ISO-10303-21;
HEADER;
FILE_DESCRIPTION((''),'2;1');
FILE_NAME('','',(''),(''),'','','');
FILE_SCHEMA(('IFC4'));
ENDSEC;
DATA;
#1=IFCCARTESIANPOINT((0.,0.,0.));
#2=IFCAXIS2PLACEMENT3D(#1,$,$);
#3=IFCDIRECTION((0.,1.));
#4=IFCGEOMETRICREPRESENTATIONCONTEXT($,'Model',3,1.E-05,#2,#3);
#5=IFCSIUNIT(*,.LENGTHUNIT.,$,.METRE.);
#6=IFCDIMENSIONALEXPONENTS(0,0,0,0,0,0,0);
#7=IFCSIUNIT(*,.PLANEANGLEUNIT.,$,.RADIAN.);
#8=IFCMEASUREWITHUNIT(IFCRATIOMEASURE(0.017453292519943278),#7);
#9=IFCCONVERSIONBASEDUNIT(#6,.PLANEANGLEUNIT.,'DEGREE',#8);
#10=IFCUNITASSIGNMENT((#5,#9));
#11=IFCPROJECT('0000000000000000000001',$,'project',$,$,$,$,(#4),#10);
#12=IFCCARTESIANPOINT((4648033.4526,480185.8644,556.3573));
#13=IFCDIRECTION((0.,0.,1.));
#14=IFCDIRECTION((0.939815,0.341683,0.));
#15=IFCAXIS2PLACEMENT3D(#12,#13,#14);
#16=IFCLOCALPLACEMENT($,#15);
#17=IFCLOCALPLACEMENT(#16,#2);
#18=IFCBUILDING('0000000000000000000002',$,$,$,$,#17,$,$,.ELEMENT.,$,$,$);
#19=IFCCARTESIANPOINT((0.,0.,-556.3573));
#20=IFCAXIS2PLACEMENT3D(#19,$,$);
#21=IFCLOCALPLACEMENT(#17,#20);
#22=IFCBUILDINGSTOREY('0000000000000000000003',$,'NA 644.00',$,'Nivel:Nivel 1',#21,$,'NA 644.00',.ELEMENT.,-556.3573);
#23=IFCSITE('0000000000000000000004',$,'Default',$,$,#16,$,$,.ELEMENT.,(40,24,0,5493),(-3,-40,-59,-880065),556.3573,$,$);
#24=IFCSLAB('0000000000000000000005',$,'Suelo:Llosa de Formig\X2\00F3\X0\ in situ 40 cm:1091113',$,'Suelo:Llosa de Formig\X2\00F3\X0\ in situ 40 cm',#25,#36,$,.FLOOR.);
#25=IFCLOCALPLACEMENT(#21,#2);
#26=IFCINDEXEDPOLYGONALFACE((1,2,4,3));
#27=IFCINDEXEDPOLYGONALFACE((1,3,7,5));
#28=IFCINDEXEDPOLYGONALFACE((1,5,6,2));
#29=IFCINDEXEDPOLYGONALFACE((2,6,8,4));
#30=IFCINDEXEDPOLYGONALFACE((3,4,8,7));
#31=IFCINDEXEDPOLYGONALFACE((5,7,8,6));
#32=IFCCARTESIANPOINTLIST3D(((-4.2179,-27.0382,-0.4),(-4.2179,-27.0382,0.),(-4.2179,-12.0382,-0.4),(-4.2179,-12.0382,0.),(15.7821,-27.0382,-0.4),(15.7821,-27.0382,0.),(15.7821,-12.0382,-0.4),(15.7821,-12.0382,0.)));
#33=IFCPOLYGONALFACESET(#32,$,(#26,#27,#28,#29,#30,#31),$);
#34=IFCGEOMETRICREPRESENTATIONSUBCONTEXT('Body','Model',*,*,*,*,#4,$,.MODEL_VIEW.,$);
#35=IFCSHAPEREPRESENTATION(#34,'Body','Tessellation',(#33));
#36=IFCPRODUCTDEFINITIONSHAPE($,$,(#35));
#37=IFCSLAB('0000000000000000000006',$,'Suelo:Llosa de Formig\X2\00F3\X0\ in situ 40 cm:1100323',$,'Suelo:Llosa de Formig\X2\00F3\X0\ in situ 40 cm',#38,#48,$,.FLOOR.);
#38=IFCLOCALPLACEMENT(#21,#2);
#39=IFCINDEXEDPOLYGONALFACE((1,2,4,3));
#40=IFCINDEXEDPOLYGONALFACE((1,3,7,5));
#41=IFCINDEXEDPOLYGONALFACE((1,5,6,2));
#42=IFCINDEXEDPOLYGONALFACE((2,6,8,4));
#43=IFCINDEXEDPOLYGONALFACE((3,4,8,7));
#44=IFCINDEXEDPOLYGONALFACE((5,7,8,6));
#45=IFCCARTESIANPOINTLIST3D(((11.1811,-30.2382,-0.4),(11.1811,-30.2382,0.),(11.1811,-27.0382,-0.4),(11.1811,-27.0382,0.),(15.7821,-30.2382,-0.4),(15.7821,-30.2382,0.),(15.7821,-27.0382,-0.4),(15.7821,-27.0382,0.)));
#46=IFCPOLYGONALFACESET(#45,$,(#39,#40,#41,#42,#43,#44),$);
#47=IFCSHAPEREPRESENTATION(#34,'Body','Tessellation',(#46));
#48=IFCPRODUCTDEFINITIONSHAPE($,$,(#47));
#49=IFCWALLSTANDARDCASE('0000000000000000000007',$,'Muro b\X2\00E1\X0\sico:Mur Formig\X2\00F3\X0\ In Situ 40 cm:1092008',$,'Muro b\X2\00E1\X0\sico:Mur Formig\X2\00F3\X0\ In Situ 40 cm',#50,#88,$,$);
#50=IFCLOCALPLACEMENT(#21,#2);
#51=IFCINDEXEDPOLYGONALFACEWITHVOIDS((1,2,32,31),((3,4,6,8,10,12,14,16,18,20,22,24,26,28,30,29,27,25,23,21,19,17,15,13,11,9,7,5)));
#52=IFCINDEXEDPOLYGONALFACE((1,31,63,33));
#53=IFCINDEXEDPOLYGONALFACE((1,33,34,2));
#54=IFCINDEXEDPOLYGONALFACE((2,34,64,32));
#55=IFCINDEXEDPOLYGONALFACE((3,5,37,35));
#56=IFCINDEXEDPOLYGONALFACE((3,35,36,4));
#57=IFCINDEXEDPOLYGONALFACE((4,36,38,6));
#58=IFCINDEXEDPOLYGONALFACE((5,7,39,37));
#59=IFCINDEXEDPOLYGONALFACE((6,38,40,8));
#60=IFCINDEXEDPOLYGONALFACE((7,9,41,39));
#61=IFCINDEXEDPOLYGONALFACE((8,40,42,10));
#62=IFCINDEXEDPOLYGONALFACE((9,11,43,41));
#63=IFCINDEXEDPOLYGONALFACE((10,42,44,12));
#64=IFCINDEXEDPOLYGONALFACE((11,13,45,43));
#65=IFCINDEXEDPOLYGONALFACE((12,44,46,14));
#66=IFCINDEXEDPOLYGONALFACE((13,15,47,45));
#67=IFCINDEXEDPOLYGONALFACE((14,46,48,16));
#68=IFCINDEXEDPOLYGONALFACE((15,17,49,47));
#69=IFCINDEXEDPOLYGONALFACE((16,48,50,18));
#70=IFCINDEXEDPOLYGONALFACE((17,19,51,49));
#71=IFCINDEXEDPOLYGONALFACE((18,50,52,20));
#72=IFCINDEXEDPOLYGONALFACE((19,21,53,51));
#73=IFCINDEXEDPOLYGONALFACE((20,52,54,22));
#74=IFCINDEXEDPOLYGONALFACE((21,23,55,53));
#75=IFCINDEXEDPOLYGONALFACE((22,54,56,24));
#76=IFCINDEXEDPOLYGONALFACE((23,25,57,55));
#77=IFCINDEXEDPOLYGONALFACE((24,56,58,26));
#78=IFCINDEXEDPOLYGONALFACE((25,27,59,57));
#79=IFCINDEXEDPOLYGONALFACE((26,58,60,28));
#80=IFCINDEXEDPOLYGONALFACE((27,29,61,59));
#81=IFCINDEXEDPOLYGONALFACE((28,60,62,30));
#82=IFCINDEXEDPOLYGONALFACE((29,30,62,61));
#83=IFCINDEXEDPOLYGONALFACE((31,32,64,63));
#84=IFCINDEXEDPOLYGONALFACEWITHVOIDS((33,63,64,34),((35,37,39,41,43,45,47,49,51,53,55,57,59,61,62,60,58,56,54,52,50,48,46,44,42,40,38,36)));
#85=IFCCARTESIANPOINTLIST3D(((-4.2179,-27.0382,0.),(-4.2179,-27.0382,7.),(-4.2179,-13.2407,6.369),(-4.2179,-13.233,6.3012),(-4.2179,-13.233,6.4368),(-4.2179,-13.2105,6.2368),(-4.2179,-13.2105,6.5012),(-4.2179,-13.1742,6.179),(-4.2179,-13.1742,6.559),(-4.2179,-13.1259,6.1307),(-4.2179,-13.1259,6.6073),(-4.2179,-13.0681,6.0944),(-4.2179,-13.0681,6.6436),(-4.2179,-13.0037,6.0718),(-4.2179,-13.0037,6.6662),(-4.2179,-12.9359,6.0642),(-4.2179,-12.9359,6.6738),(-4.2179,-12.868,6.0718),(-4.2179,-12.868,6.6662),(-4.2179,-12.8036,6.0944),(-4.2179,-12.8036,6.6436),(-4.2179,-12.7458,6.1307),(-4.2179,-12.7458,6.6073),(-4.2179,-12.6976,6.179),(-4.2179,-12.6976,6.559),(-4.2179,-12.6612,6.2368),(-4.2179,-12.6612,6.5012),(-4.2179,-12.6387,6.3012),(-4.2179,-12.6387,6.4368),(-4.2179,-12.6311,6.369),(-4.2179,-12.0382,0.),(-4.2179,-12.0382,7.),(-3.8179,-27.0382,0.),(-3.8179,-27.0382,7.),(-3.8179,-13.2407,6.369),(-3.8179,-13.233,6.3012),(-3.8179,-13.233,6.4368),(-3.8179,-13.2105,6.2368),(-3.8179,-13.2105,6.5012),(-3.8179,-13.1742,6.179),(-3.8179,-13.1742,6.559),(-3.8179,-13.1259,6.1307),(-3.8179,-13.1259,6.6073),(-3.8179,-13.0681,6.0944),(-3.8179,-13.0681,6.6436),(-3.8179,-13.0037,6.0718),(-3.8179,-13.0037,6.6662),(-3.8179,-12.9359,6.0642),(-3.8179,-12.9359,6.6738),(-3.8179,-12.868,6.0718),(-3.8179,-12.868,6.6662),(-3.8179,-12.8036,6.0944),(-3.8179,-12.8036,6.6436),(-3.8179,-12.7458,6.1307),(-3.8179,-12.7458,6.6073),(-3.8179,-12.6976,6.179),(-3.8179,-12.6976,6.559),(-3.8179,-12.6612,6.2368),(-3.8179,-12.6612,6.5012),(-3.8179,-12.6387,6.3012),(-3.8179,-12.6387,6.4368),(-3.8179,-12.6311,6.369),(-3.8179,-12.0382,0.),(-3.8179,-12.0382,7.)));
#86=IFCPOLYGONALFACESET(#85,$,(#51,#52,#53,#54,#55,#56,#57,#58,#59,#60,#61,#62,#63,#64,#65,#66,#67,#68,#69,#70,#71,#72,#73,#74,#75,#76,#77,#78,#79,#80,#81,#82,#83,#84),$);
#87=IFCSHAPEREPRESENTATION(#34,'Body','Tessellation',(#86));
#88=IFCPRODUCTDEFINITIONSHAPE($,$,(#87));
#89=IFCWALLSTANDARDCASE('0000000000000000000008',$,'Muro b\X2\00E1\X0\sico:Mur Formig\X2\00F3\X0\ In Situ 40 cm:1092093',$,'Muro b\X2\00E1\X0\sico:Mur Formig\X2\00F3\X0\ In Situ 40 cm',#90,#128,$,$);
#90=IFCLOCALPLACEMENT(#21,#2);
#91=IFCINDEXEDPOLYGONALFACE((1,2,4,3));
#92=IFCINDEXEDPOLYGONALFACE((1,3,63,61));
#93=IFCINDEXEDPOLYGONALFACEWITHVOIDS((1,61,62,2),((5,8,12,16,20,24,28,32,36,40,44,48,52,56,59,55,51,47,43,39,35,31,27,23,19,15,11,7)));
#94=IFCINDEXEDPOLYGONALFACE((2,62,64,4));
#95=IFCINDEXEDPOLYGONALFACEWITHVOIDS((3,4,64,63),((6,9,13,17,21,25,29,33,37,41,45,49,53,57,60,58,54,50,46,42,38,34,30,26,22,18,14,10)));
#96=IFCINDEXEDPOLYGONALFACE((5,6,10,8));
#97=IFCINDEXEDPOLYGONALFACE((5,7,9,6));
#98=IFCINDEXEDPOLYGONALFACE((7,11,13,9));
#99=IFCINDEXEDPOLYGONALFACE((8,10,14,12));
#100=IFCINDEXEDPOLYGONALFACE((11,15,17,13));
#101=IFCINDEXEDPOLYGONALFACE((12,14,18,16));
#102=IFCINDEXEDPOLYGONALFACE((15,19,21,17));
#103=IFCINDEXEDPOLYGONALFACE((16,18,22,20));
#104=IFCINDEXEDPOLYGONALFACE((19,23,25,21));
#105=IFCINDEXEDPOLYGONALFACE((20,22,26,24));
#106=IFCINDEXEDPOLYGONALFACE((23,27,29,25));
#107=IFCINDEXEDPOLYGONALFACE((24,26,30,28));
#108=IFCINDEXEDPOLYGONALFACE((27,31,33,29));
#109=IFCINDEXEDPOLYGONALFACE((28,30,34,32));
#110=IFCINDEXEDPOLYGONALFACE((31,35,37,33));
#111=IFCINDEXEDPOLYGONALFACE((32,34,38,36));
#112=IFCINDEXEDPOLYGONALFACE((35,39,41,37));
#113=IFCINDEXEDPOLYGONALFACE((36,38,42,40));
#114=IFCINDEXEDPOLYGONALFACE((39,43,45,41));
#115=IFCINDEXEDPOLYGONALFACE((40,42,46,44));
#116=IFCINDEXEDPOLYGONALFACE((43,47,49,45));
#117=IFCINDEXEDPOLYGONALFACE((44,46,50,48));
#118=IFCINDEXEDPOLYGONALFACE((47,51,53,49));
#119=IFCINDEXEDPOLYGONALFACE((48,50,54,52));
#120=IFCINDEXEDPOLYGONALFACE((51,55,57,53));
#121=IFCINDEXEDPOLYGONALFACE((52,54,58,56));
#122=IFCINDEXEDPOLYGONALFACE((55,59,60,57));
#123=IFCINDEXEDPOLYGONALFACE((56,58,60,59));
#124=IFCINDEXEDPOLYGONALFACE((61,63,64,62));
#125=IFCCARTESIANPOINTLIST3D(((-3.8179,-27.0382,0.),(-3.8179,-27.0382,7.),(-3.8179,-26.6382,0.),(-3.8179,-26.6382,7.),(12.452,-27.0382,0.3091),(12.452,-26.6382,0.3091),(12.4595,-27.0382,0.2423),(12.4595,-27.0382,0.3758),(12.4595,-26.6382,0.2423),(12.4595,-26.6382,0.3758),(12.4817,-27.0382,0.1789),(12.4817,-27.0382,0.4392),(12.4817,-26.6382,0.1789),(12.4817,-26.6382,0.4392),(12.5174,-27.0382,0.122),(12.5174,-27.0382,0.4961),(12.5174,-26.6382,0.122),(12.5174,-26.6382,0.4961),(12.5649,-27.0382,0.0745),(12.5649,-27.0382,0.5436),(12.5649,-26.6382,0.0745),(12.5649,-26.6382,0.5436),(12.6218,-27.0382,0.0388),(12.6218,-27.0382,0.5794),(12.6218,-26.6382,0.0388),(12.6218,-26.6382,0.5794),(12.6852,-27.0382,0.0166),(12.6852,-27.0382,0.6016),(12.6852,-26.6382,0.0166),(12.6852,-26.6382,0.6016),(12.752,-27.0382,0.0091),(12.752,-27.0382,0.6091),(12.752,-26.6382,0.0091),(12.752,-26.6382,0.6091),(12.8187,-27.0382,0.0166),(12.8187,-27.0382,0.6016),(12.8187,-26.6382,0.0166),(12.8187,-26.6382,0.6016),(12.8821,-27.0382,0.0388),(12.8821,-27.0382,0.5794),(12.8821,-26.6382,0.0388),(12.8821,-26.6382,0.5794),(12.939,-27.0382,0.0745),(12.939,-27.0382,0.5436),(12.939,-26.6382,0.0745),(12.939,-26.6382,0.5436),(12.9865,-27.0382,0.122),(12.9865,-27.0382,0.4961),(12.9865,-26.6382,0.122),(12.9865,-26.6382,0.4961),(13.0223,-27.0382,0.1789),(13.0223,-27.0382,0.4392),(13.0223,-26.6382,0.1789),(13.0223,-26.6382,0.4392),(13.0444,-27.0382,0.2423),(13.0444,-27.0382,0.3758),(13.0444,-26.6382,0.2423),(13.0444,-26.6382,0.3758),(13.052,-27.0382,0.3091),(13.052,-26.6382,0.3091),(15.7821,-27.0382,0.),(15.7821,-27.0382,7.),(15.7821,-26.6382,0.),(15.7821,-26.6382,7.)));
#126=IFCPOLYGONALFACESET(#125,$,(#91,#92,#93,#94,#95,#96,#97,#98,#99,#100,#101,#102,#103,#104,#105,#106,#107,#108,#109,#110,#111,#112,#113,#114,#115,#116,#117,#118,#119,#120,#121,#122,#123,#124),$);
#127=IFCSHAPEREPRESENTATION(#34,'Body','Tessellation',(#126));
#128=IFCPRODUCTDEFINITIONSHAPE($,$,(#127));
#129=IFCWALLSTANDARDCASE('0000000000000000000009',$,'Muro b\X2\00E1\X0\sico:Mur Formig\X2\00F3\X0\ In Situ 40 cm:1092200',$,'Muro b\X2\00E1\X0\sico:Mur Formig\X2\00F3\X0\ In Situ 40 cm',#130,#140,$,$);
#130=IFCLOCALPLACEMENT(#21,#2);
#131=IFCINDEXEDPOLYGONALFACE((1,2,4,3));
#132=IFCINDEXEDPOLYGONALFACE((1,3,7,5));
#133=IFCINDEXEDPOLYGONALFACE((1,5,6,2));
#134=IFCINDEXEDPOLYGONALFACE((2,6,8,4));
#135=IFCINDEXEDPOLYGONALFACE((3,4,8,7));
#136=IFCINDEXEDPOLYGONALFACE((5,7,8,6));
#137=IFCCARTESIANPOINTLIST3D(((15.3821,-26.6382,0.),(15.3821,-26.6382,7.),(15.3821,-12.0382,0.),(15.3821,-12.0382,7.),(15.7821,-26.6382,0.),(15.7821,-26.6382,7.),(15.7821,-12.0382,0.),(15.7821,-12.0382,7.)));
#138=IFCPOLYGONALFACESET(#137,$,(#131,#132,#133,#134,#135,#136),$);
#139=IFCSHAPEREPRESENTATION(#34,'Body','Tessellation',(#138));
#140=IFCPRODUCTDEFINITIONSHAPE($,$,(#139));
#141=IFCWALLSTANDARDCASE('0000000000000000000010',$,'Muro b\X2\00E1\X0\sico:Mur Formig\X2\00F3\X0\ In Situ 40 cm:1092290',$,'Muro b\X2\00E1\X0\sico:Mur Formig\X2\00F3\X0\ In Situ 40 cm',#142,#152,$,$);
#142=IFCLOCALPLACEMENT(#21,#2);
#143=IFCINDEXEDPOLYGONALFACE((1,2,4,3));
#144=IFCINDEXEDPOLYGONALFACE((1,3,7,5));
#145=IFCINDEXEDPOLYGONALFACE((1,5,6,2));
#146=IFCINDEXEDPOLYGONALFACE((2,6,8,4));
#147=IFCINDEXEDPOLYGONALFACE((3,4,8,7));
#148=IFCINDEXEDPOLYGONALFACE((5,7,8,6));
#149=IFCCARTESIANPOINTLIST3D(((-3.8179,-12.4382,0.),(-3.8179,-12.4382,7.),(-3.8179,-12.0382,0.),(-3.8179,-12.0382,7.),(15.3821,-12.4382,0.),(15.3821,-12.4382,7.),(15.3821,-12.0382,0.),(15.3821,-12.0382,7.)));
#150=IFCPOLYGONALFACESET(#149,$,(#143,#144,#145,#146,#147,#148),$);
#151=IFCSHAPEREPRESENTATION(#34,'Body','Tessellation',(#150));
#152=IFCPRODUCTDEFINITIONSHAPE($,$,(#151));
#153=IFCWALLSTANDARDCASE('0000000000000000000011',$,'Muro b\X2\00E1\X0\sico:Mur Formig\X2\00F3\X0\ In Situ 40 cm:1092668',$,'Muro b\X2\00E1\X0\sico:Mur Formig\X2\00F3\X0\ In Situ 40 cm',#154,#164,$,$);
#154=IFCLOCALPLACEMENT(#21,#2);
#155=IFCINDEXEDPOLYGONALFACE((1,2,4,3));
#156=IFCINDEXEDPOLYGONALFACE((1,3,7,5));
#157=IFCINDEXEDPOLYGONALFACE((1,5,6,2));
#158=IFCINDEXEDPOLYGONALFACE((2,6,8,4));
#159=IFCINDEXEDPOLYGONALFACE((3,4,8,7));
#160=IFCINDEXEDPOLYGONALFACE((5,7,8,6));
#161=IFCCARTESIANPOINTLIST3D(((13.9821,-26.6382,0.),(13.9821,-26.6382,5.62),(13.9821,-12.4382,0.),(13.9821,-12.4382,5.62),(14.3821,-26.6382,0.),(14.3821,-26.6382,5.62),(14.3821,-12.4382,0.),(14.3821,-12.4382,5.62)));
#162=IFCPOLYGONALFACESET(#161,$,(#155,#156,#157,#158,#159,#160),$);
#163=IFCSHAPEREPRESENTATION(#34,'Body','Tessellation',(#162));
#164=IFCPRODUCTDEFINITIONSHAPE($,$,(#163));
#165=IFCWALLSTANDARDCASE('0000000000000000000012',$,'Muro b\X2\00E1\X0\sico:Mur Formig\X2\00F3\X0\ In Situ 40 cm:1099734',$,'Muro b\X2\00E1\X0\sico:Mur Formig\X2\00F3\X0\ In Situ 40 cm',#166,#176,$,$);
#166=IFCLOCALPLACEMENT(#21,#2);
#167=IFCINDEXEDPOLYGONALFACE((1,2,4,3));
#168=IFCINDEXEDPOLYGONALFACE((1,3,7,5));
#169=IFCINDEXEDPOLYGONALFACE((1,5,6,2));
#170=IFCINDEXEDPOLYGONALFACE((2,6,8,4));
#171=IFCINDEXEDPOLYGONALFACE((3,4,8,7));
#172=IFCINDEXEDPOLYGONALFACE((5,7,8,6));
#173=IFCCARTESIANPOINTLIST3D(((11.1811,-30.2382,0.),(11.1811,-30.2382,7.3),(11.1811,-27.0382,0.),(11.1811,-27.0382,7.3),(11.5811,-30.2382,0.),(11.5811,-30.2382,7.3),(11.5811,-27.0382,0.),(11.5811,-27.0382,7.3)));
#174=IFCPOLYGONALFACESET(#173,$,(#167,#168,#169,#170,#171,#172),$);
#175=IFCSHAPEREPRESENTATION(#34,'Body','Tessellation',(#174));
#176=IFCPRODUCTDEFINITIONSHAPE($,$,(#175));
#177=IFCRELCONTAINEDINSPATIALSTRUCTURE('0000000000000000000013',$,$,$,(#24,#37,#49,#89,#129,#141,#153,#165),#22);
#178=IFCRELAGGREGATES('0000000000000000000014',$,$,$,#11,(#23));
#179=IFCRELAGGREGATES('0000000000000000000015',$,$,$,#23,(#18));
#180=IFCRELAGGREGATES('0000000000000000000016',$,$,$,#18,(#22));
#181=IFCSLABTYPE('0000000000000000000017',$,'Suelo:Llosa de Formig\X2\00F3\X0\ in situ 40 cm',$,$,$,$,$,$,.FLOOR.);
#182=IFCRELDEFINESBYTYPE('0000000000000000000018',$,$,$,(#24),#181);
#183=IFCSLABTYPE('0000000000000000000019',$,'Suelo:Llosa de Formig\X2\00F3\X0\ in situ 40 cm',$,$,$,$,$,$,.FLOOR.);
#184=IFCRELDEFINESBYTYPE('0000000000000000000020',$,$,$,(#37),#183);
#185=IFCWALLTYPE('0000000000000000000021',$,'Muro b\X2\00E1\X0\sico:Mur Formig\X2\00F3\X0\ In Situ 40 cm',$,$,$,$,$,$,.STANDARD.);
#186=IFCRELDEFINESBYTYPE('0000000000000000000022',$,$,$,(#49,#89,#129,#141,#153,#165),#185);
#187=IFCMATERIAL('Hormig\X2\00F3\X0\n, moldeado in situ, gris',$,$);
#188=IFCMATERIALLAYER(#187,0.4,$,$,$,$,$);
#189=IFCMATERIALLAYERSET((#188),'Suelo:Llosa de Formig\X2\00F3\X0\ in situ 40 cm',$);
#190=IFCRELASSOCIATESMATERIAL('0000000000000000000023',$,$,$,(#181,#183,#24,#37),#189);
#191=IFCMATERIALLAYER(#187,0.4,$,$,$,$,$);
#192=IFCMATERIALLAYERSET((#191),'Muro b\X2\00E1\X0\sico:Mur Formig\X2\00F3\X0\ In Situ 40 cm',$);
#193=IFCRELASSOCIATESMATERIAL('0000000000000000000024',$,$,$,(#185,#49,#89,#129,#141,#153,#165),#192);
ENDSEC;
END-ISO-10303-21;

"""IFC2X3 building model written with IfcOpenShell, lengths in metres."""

from ifc_helpers import new_model, entity, si_unit, converted_unit, direction, frame, frame_2d, origin, origin_2d_with_axis, place, context, subcontext, project, spatial, rectangle, circle, extrude, material, layer, layer_set, layer_usage, type_object, element, save


model = new_model("IFC2X3")

# Units and contexts
model_context = context("Model", 3, precision=1e-05, world=origin(), true_north=direction((0.0, 1.0)))
body_context = subcontext(model_context, "Body", "Model", "MODEL_VIEW")
ifc_project = project(units=[si_unit("LENGTHUNIT", "METRE"), converted_unit("PLANEANGLEUNIT", "DEGREE", entity("IfcRatioMeasure", 0.017453292519943278), si_unit("PLANEANGLEUNIT", "RADIAN"), dimensions=[0, 0, 0, 0, 0, 0, 0])], contexts=[model_context])

# Site, building, storey
site_placement = place(None, frame((4648033.4526, 480185.8644, 556.3573), z_axis=(0.0, 0.0, 1.0), x_axis=(0.939815, 0.341683, 0.0)))
site = spatial("IfcSite", under=ifc_project, at=site_placement, Name="Default", CompositionType="ELEMENT", RefLatitude=(40, 24, 0, 5493), RefLongitude=(-3, -40, -59, -880065), RefElevation=556.3573)
building_placement = place(site_placement, origin())
building = spatial("IfcBuilding", under=site, at=building_placement, CompositionType="ELEMENT")
storey_placement = place(building_placement, frame((0.0, 0.0, -556.3573)))
storey = spatial("IfcBuildingStorey", under=building, at=storey_placement, Name="NA 644.00", ObjectType="Nivel:Nivel 1", LongName="NA 644.00", CompositionType="ELEMENT", Elevation=-556.3573)

# Slabs
ifc_material_1 = material(Name="Hormigón, moldeado in situ, gris")
ifc_layer_1 = layer(ifc_material_1, 0.4)
ifc_layer_set_1 = layer_set([ifc_layer_1], Name="Suelo:Llosa de Formigó in situ 40 cm")
ifc_layer_usage_1 = layer_usage(ifc_layer_set_1, "AXIS3", "POSITIVE", 0.0)
slab_type_1 = type_object("IfcSlabType", Name="Suelo:Llosa de Formigó in situ 40 cm", PredefinedType="FLOOR", material=ifc_layer_set_1)
slab_1_placement = place(storey_placement, origin())
element("IfcSlab", 1, at=slab_1_placement, inside=storey, type_object=slab_type_1, material=ifc_layer_usage_1, Name="Suelo:Llosa de Formigó in situ 40 cm:1091113", ObjectType="Suelo:Llosa de Formigó in situ 40 cm", PredefinedType="FLOOR", context=body_context, shape_type="SweptSolid", body=[
    extrude(rectangle(XDim=15.0, YDim=20.0, at=frame_2d((0.0, 0.0), x_axis=(1.0, 0.0))), frame((5.7821, -19.5382, 0.0), z_axis=(0.0, 0.0, -1.0), x_axis=(0.0, 1.0, 0.0)), (0.0, 0.0, 1.0), 0.4),
])
ifc_layer_usage_2 = layer_usage(ifc_layer_set_1, "AXIS3", "POSITIVE", 0.0)
slab_type_2 = type_object("IfcSlabType", Name="Suelo:Llosa de Formigó in situ 40 cm", PredefinedType="FLOOR", material=ifc_layer_set_1)
slab_2_placement = place(storey_placement, origin())
element("IfcSlab", 2, at=slab_2_placement, inside=storey, type_object=slab_type_2, material=ifc_layer_usage_2, Name="Suelo:Llosa de Formigó in situ 40 cm:1100323", ObjectType="Suelo:Llosa de Formigó in situ 40 cm", PredefinedType="FLOOR", context=body_context, shape_type="SweptSolid", body=[
    extrude(rectangle(XDim=3.2, YDim=4.601, at=frame_2d((0.0, 0.0), x_axis=(1.0, 0.0))), frame((13.4816, -28.6382, 0.0), z_axis=(0.0, 0.0, -1.0), x_axis=(0.0, 1.0, 0.0)), (0.0, 0.0, 1.0), 0.4),
])

# Walls, openings
ifc_layer_2 = layer(ifc_material_1, 0.4)
ifc_layer_set_2 = layer_set([ifc_layer_2], Name="Muro básico:Mur Formigó In Situ 40 cm")
ifc_layer_usage_3 = layer_usage(ifc_layer_set_2, "AXIS2", "NEGATIVE", 0.2)
wall_type = type_object("IfcWallType", Name="Muro básico:Mur Formigó In Situ 40 cm", PredefinedType="STANDARD", material=ifc_layer_set_2)
wall_1_placement = place(storey_placement, frame((-4.0179, -12.0382, 0.0), z_axis=(0.0, 0.0, 1.0), x_axis=(0.0, -1.0, 0.0)))
wall_1 = element("IfcWallStandardCase", 3, at=wall_1_placement, inside=storey, type_object=wall_type, material=ifc_layer_usage_3, Name="Muro básico:Mur Formigó In Situ 40 cm:1092008", ObjectType="Muro básico:Mur Formigó In Situ 40 cm", context=body_context, shape_type="SweptSolid", body=[
    extrude(rectangle(XDim=15.0, YDim=0.4, at=frame_2d((7.5, 0.0), x_axis=(-1.0, 0.0))), origin(), (0.0, 0.0, 1.0), 7.0),
])
opening_1_placement = place(wall_1_placement, origin())
element("IfcOpeningElement", 4, at=opening_1_placement, cuts=wall_1, ObjectType="Opening", context=body_context, shape_type="SweptSolid", body=[
    extrude(circle(Radius=0.3048, at=origin_2d_with_axis()), frame((0.8977, 0.2, 6.369), z_axis=(0.0, -1.0, 0.0), x_axis=(-1.0, 0.0, 0.0)), (0.0, 0.0, 1.0), 0.4),
])
ifc_layer_usage_4 = layer_usage(ifc_layer_set_2, "AXIS2", "NEGATIVE", 0.2)
wall_2_placement = place(storey_placement, frame((-3.8179, -26.8382, 0.0)))
wall_2 = element("IfcWallStandardCase", 5, at=wall_2_placement, inside=storey, type_object=wall_type, material=ifc_layer_usage_4, Name="Muro básico:Mur Formigó In Situ 40 cm:1092093", ObjectType="Muro básico:Mur Formigó In Situ 40 cm", context=body_context, shape_type="SweptSolid", body=[
    extrude(rectangle(XDim=19.6, YDim=0.4, at=frame_2d((9.8, 0.0), x_axis=(-1.0, 0.0))), origin(), (0.0, 0.0, 1.0), 7.0),
])
opening_2_placement = place(wall_2_placement, origin())
element("IfcOpeningElement", 6, at=opening_2_placement, cuts=wall_2, ObjectType="Opening", context=body_context, shape_type="SweptSolid", body=[
    extrude(circle(Radius=0.3, at=origin_2d_with_axis()), frame((16.5699, 0.2, 0.3091), z_axis=(0.0, -1.0, 0.0), x_axis=(-1.0, 0.0, 0.0)), (0.0, 0.0, 1.0), 0.4),
])

# Walls
ifc_layer_usage_5 = layer_usage(ifc_layer_set_2, "AXIS2", "NEGATIVE", 0.2)
wall_3_placement = place(storey_placement, frame((15.5821, -26.6382, 0.0), z_axis=(0.0, 0.0, 1.0), x_axis=(0.0, 1.0, 0.0)))
element("IfcWallStandardCase", 7, at=wall_3_placement, inside=storey, type_object=wall_type, material=ifc_layer_usage_5, Name="Muro básico:Mur Formigó In Situ 40 cm:1092200", ObjectType="Muro básico:Mur Formigó In Situ 40 cm", context=body_context, shape_type="SweptSolid", body=[
    extrude(rectangle(XDim=14.6, YDim=0.4, at=frame_2d((7.3, 0.0), x_axis=(-1.0, 0.0))), origin(), (0.0, 0.0, 1.0), 7.0),
])
ifc_layer_usage_6 = layer_usage(ifc_layer_set_2, "AXIS2", "NEGATIVE", 0.2)
wall_4_placement = place(storey_placement, frame((15.3821, -12.2382, 0.0), z_axis=(0.0, 0.0, 1.0), x_axis=(-1.0, 0.0, 0.0)))
element("IfcWallStandardCase", 8, at=wall_4_placement, inside=storey, type_object=wall_type, material=ifc_layer_usage_6, Name="Muro básico:Mur Formigó In Situ 40 cm:1092290", ObjectType="Muro básico:Mur Formigó In Situ 40 cm", context=body_context, shape_type="SweptSolid", body=[
    extrude(rectangle(XDim=19.2, YDim=0.4, at=frame_2d((9.6, 0.0), x_axis=(-1.0, 0.0))), origin(), (0.0, 0.0, 1.0), 7.0),
])
ifc_layer_usage_7 = layer_usage(ifc_layer_set_2, "AXIS2", "NEGATIVE", 0.2)
wall_5_placement = place(storey_placement, frame((14.1821, -12.4382, 0.0), z_axis=(0.0, 0.0, 1.0), x_axis=(0.0, -1.0, 0.0)))
element("IfcWallStandardCase", 9, at=wall_5_placement, inside=storey, type_object=wall_type, material=ifc_layer_usage_7, Name="Muro básico:Mur Formigó In Situ 40 cm:1092668", ObjectType="Muro básico:Mur Formigó In Situ 40 cm", context=body_context, shape_type="SweptSolid", body=[
    extrude(rectangle(XDim=14.2, YDim=0.4, at=frame_2d((7.1, 0.0), x_axis=(-1.0, 0.0))), origin(), (0.0, 0.0, 1.0), 5.62),
])
ifc_layer_usage_8 = layer_usage(ifc_layer_set_2, "AXIS2", "NEGATIVE", 0.2)
wall_6_placement = place(storey_placement, frame((11.3811, -27.0382, 0.0), z_axis=(0.0, 0.0, 1.0), x_axis=(0.0, -1.0, 0.0)))
element("IfcWallStandardCase", 10, at=wall_6_placement, inside=storey, type_object=wall_type, material=ifc_layer_usage_8, Name="Muro básico:Mur Formigó In Situ 40 cm:1099734", ObjectType="Muro básico:Mur Formigó In Situ 40 cm", context=body_context, shape_type="SweptSolid", body=[
    extrude(rectangle(XDim=3.2, YDim=0.4, at=frame_2d((1.6, 0.0), x_axis=(-1.0, 0.0))), origin(), (0.0, 0.0, 1.0), 7.3),
])

save(model, "model.ifc")
